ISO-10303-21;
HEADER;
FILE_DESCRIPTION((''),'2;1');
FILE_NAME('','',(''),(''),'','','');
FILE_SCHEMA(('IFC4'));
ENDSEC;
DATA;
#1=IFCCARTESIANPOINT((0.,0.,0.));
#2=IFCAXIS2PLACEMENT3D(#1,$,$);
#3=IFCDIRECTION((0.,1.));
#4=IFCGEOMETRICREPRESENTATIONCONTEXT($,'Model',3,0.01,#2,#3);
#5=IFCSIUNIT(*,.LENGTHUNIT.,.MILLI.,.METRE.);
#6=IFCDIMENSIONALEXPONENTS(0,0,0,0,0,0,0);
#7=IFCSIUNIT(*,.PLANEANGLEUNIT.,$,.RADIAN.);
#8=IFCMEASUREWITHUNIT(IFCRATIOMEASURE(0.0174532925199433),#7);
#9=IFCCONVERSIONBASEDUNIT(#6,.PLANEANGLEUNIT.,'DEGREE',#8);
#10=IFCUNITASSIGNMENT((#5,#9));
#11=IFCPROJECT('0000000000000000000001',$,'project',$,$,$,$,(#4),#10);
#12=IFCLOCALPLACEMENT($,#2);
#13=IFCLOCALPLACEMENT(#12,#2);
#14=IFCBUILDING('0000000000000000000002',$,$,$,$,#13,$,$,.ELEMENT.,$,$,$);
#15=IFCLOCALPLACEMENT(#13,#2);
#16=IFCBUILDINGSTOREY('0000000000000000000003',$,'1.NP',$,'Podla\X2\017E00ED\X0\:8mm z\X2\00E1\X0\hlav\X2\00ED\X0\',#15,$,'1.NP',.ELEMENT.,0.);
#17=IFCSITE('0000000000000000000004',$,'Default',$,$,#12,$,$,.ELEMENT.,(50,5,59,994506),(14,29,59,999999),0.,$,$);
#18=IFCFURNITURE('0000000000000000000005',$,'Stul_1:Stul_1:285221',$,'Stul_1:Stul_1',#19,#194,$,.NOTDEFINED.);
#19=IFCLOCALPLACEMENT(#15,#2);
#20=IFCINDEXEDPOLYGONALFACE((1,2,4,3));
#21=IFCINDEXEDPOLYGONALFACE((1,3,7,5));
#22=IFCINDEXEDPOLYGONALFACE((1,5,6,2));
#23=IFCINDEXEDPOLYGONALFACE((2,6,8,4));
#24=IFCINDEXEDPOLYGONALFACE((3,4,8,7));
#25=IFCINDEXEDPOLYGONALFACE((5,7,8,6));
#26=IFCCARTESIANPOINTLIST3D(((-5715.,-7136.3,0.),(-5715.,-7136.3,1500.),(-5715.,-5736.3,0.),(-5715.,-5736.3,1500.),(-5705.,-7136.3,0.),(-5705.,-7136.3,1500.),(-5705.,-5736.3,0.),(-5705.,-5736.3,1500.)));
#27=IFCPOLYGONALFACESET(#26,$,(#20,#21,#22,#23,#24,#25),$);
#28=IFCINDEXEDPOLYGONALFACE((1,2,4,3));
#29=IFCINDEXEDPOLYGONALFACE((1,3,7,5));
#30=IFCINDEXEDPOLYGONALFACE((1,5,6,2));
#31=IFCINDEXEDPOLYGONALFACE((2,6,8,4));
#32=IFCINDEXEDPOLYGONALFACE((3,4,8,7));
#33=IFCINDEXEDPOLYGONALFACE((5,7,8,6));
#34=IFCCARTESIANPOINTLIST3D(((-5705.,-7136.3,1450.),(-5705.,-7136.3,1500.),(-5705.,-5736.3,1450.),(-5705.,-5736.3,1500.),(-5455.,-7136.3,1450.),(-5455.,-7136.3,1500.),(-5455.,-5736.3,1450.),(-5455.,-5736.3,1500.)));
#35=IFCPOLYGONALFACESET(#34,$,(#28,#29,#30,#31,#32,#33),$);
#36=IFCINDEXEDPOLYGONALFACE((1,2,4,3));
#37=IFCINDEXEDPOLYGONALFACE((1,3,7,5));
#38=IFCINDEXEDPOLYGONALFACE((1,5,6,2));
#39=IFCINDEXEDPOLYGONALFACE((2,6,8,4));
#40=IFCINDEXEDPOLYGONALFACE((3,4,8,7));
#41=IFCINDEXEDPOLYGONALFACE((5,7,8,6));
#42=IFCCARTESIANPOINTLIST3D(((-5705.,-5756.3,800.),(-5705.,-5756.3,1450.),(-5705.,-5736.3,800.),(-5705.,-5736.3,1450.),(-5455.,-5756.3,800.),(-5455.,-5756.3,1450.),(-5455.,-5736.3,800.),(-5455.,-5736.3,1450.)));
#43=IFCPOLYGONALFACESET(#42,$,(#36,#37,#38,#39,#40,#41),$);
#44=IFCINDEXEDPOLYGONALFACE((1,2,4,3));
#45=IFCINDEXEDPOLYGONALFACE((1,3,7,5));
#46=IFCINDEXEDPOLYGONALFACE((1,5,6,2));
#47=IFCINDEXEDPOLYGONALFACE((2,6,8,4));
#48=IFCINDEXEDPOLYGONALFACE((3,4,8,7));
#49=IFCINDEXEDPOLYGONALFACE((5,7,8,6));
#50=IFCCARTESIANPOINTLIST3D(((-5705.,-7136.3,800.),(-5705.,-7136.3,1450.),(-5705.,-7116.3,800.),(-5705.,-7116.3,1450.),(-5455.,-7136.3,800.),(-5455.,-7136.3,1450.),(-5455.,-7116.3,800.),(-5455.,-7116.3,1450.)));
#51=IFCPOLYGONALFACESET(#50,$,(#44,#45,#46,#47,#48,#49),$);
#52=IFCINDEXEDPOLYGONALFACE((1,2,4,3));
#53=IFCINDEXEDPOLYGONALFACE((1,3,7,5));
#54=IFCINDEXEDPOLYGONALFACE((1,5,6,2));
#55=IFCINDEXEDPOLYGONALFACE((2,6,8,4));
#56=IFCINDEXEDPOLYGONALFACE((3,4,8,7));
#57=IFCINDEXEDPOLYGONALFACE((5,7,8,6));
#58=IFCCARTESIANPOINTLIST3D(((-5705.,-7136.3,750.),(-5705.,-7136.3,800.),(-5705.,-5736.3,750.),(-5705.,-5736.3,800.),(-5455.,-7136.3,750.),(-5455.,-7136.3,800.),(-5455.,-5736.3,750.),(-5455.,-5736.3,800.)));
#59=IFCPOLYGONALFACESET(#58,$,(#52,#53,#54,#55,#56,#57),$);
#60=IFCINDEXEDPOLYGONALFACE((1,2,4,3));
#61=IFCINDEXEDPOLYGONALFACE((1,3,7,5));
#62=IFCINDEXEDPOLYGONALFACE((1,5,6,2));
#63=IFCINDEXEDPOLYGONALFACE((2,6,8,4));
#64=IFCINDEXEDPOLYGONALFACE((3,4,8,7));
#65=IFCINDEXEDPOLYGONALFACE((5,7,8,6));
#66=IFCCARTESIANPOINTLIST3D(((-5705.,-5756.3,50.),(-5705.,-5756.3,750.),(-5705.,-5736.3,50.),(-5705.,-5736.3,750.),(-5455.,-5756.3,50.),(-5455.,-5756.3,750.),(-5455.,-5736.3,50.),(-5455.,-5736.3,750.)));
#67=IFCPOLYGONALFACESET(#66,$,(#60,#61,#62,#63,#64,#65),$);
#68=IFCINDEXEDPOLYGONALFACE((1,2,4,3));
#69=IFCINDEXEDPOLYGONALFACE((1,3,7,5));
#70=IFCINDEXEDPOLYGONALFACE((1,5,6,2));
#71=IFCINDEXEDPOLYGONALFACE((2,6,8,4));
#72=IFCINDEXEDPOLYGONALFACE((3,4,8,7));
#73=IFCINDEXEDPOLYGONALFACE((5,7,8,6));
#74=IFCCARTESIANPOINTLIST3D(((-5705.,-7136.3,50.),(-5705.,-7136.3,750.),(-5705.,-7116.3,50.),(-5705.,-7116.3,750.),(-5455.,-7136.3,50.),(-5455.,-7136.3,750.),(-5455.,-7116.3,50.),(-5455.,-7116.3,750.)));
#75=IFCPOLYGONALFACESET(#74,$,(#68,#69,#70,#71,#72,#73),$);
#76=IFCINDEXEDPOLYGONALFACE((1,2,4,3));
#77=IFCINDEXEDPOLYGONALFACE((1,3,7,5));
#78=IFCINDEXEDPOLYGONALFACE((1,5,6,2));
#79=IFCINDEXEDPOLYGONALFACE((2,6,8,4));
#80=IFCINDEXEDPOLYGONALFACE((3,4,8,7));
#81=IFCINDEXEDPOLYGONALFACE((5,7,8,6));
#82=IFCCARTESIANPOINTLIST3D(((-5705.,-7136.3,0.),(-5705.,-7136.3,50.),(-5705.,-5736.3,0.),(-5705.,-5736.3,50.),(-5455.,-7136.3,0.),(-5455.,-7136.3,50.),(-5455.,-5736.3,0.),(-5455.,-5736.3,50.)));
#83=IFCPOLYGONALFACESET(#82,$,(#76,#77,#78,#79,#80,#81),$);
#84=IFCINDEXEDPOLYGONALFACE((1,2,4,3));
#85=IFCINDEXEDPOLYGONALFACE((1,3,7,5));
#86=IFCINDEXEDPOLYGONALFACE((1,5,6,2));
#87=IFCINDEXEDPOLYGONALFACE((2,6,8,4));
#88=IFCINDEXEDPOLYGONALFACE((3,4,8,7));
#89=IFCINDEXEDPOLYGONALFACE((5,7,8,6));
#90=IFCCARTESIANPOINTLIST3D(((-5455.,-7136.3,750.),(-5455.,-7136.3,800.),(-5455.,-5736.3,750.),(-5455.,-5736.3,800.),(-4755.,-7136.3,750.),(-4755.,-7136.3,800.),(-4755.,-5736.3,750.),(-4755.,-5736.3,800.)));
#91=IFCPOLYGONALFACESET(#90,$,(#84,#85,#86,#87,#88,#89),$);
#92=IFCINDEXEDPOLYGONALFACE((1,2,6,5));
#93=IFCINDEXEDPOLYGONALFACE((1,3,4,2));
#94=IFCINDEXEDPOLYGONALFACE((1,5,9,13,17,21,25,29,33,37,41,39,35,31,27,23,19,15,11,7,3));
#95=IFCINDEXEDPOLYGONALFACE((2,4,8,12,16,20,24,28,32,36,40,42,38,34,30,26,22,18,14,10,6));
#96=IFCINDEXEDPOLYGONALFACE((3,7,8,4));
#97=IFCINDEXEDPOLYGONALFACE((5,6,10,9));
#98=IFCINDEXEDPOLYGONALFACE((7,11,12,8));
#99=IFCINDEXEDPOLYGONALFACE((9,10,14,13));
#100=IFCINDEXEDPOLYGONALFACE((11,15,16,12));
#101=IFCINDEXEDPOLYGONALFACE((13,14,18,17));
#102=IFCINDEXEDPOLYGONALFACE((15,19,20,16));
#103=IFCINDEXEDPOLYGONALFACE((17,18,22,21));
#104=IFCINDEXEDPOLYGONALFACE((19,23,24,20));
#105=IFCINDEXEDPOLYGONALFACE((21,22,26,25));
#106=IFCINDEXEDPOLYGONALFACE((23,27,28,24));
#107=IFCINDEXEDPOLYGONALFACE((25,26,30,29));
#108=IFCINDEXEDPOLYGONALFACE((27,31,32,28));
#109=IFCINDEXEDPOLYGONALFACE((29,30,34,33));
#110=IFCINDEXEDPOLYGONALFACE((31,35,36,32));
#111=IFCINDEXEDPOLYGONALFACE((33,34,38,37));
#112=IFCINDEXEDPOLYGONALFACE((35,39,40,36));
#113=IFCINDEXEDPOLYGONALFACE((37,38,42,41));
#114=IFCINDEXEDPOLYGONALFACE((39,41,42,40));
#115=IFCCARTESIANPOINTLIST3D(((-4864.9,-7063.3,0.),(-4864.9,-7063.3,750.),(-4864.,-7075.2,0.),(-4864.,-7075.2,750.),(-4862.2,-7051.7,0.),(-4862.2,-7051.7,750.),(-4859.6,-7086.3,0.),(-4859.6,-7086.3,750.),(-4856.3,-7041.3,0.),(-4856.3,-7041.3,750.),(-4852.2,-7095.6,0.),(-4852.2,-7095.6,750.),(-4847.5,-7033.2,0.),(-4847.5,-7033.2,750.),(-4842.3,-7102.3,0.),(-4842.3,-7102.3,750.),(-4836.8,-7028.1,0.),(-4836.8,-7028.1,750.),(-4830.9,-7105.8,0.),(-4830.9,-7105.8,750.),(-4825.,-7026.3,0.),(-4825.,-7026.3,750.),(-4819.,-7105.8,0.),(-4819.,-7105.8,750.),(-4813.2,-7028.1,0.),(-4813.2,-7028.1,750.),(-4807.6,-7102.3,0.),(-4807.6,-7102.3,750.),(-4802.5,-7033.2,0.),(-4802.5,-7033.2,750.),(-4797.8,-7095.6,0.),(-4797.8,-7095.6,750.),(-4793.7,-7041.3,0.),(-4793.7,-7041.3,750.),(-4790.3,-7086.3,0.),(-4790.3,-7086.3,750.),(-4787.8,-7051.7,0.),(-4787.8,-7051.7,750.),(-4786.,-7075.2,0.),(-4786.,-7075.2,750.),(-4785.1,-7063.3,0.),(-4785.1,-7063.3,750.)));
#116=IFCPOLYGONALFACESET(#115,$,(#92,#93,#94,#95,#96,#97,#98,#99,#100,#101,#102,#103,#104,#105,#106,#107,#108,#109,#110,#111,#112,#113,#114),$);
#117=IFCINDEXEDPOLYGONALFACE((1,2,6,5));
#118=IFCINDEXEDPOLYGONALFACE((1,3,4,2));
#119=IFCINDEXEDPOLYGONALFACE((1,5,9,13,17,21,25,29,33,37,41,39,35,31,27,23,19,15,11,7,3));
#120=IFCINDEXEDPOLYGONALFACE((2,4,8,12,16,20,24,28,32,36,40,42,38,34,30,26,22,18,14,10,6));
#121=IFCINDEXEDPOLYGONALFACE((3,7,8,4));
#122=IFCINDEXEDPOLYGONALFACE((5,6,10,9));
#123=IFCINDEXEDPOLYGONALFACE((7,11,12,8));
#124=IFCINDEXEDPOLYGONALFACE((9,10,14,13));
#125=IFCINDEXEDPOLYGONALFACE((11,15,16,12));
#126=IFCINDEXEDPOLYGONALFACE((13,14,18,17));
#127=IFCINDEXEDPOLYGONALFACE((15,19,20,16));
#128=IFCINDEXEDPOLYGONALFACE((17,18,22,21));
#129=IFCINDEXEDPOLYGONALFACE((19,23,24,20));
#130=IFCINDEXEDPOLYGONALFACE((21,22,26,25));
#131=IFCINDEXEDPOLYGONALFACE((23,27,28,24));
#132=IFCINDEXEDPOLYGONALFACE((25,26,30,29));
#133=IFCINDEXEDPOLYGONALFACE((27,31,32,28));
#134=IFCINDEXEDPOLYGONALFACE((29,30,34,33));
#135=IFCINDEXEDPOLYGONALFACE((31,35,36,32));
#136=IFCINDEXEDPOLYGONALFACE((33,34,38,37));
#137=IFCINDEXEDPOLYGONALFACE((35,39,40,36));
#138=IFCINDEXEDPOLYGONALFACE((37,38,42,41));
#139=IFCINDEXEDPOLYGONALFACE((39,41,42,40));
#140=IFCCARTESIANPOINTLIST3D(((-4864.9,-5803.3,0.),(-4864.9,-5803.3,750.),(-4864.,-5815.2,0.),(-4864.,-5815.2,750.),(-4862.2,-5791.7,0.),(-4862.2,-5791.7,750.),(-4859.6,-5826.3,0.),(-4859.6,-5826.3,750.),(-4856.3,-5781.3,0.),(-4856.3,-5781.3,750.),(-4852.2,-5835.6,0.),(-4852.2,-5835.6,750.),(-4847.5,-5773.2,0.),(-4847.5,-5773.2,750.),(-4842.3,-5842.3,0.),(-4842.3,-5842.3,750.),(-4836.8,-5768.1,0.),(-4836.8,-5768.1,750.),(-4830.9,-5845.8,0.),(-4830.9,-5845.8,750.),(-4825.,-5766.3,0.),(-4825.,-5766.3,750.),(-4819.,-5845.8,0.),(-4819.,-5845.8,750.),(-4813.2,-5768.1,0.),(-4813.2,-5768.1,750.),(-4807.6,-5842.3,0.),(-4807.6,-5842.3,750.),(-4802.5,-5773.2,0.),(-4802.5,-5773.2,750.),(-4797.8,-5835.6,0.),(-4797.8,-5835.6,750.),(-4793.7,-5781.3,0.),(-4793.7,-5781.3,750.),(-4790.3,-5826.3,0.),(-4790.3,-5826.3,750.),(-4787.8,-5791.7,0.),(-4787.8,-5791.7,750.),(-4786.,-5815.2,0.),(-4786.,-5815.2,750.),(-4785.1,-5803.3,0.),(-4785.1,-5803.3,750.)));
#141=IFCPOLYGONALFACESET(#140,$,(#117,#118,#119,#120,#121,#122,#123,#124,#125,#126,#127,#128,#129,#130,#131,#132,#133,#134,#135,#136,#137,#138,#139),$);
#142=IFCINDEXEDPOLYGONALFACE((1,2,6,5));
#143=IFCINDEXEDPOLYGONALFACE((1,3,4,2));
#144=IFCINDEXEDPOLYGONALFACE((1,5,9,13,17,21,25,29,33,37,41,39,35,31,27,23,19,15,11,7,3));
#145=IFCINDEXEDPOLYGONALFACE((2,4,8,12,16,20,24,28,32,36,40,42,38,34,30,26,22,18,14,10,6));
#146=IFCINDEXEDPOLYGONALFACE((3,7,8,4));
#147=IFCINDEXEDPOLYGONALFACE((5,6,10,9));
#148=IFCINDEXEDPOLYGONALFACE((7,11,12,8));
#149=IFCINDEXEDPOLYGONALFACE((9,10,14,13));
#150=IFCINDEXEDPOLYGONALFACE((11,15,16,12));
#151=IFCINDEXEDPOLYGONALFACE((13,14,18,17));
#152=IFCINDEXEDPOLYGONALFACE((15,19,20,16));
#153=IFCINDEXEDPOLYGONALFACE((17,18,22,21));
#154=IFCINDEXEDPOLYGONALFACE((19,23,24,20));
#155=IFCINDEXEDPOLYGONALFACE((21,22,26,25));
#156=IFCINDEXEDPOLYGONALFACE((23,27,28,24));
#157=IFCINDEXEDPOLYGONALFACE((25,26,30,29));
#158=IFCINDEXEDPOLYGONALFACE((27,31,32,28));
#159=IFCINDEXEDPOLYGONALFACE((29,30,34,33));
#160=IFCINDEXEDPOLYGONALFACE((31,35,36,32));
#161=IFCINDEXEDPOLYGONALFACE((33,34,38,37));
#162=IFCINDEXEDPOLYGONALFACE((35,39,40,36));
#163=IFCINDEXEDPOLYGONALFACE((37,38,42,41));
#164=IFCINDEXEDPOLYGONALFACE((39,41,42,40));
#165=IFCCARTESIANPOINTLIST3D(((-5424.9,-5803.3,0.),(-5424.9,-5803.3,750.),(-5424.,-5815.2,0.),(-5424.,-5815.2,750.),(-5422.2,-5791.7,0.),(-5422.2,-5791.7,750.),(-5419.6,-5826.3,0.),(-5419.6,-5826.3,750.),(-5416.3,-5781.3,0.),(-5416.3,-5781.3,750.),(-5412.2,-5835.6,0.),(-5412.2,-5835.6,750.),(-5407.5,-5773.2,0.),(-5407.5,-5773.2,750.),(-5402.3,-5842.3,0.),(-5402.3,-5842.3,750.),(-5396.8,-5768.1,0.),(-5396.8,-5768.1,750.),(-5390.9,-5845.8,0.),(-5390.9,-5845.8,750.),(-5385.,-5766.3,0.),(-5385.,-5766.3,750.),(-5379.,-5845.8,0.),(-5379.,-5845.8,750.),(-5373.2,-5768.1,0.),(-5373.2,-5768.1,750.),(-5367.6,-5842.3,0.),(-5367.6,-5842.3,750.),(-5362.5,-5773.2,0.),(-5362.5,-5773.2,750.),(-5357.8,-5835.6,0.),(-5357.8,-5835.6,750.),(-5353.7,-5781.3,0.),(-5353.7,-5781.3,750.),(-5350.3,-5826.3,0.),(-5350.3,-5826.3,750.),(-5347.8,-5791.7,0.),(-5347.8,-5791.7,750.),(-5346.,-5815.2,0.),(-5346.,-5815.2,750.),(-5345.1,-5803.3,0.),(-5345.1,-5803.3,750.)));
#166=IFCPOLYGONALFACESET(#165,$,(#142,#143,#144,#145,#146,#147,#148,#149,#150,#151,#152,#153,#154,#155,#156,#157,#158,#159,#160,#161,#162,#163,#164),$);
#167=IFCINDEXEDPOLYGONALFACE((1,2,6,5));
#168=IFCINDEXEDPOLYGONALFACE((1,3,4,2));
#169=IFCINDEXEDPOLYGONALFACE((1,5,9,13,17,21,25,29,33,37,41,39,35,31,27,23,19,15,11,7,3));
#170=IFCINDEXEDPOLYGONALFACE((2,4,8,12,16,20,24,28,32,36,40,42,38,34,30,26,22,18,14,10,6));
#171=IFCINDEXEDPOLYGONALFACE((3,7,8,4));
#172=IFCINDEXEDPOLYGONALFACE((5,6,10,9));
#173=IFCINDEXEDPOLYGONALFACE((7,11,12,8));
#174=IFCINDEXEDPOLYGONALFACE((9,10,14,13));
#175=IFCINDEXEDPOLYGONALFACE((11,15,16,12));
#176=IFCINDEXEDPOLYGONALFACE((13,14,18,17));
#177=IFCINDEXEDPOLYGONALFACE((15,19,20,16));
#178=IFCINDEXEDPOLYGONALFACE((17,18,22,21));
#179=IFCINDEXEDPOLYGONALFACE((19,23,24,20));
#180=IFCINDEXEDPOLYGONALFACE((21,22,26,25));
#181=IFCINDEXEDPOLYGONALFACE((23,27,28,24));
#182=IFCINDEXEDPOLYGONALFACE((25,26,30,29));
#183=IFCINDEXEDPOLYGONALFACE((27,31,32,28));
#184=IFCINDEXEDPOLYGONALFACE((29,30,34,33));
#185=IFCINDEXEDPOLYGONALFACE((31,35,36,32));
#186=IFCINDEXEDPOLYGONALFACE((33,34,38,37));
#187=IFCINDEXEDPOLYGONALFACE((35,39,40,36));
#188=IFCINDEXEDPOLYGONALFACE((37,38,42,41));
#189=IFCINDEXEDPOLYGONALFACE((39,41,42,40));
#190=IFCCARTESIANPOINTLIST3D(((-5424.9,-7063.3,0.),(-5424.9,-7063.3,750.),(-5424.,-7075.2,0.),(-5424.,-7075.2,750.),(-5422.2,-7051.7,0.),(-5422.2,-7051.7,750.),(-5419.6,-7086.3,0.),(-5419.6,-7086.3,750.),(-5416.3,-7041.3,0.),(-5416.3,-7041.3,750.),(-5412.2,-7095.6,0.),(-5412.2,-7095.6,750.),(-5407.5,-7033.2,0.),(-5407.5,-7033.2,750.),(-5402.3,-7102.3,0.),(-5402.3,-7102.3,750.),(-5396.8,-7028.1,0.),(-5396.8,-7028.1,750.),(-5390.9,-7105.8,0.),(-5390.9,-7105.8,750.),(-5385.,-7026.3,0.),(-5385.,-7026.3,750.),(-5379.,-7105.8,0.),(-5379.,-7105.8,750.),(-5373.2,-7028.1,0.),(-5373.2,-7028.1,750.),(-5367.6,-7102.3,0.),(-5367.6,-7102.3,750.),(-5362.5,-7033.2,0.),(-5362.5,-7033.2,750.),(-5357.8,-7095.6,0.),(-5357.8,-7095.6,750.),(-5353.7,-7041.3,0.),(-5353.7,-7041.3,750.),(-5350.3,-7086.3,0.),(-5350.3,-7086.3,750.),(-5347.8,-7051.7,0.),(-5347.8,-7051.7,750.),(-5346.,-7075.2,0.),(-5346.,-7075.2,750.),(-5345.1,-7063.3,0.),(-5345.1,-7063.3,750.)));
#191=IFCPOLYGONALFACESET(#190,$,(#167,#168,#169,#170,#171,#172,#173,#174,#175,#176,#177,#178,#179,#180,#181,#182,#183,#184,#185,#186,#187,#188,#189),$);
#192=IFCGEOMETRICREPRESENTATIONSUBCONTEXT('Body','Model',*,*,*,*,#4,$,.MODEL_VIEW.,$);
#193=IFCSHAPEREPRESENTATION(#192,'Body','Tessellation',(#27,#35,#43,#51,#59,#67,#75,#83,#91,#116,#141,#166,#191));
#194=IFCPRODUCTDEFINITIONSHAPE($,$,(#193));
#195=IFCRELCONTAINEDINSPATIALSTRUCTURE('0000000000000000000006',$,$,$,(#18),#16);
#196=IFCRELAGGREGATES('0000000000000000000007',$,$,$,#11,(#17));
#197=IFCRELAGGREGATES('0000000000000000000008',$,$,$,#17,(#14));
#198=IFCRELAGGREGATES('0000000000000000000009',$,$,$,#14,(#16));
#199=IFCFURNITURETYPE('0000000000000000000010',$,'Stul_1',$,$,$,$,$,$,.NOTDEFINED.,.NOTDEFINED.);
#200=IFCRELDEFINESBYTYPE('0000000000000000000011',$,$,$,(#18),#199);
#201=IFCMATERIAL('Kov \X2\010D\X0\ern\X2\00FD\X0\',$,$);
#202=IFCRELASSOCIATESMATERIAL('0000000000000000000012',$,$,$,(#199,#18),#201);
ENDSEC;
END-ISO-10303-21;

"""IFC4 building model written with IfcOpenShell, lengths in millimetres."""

from ifc_helpers import new_model, entity, si_unit, converted_unit, direction, frame, frame_2d, origin, origin_2d_with_axis, place, context, subcontext, project, spatial, rectangle, circle, extrude, source, transform, mapped, material, type_object, type_shapes, element, save


model = new_model("IFC4")

# Units and contexts
model_context = context("Model", 3, precision=0.01, world=origin(), true_north=direction((0.0, 1.0)))
body_context = subcontext(model_context, "Body", "Model", "MODEL_VIEW")
ifc_project = project(units=[si_unit("LENGTHUNIT", "METRE", prefix="MILLI"), converted_unit("PLANEANGLEUNIT", "DEGREE", entity("IfcRatioMeasure", 0.0174532925199433), si_unit("PLANEANGLEUNIT", "RADIAN"), dimensions=[0, 0, 0, 0, 0, 0, 0])], contexts=[model_context])

# Site, building, storey
site_placement = place(None, origin())
site = spatial("IfcSite", under=ifc_project, at=site_placement, Name="Default", CompositionType="ELEMENT", RefLatitude=(50, 5, 59, 994506), RefLongitude=(14, 29, 59, 999999), RefElevation=0.0)
building_placement = place(site_placement, origin())
building = spatial("IfcBuilding", under=site, at=building_placement, CompositionType="ELEMENT")
storey_placement = place(building_placement, origin())
storey = spatial("IfcBuildingStorey", under=building, at=storey_placement, Name="1.NP", ObjectType="Podlaží:8mm záhlaví", LongName="1.NP", CompositionType="ELEMENT", Elevation=0.0)

# Furniture
ifc_material_1 = material(Name="Kov černý")
furniture_type = type_object("IfcFurnitureType", Name="Stul_1", AssemblyPlace="NOTDEFINED", PredefinedType="NOTDEFINED", material=ifc_material_1)
shared_shape_1 = source(origin(), body_context, "Body", "SweptSolid", [
    extrude(rectangle(XDim=1400.0, YDim=10.0, at=origin_2d_with_axis()), frame((0.0, 605.0, 0.0), z_axis=(0.0, 0.0, 1.0), x_axis=(-1.0, 0.0, 0.0)), (0.0, 0.0, 1.0), 1500.0),
    extrude(rectangle(XDim=1400.0, YDim=250.0, at=frame_2d((0.0, 0.0), x_axis=(1.0, 0.0))), frame((0.0, 475.0, 1450.0), z_axis=(0.0, 0.0, 1.0), x_axis=(-1.0, 0.0, 0.0)), (0.0, 0.0, 1.0), 50.0),
    extrude(rectangle(XDim=20.0, YDim=250.0, at=origin_2d_with_axis()), frame((690.0, 475.0, 800.0), z_axis=(0.0, 0.0, 1.0), x_axis=(-1.0, 0.0, 0.0)), (0.0, 0.0, 1.0), 650.0),
    extrude(rectangle(XDim=20.0, YDim=250.0, at=frame_2d((0.0, 0.0), x_axis=(1.0, 0.0))), frame((-690.0, 475.0, 800.0), z_axis=(0.0, 0.0, 1.0), x_axis=(-1.0, 0.0, 0.0)), (0.0, 0.0, 1.0), 650.0),
    extrude(rectangle(XDim=1400.0, YDim=250.0, at=origin_2d_with_axis()), frame((0.0, 475.0, 750.0), z_axis=(0.0, 0.0, 1.0), x_axis=(-1.0, 0.0, 0.0)), (0.0, 0.0, 1.0), 50.0),
    extrude(rectangle(XDim=20.0, YDim=250.0, at=origin_2d_with_axis()), frame((690.0, 475.0, 50.0), z_axis=(0.0, 0.0, 1.0), x_axis=(-1.0, 0.0, 0.0)), (0.0, 0.0, 1.0), 700.0),
    extrude(rectangle(XDim=20.0, YDim=250.0, at=frame_2d((0.0, 0.0), x_axis=(1.0, 0.0))), frame((-690.0, 475.0, 50.0), z_axis=(0.0, 0.0, 1.0), x_axis=(-1.0, 0.0, 0.0)), (0.0, 0.0, 1.0), 700.0),
    extrude(rectangle(XDim=1400.0, YDim=250.0, at=origin_2d_with_axis()), frame((0.0, 475.0, 0.0), z_axis=(0.0, 0.0, 1.0), x_axis=(-1.0, 0.0, 0.0)), (0.0, 0.0, 1.0), 50.0),
    extrude(rectangle(XDim=1400.0, YDim=700.0, at=origin_2d_with_axis()), frame((0.0, 0.0, 750.0), z_axis=(0.0, 0.0, 1.0), x_axis=(-1.0, 0.0, 0.0)), (0.0, 0.0, 1.0), 50.0),
    extrude(circle(Radius=40.0, at=frame_2d((0.0, 0.0), x_axis=(1.0, 0.0))), frame((-630.0, -280.0, 0.0)), (0.0, 0.0, 1.0), 750.0),
    extrude(circle(Radius=40.0, at=frame_2d((0.0, 0.0), x_axis=(1.0, 0.0))), frame((630.0, -280.0, 0.0)), (0.0, 0.0, 1.0), 750.0),
    extrude(circle(Radius=40.0, at=frame_2d((0.0, 0.0), x_axis=(1.0, 0.0))), frame((630.0, 280.0, 0.0)), (0.0, 0.0, 1.0), 750.0),
    extrude(circle(Radius=40.0, at=frame_2d((0.0, 0.0), x_axis=(1.0, 0.0))), frame((-630.0, 280.0, 0.0)), (0.0, 0.0, 1.0), 750.0),
])
type_shapes(furniture_type, [shared_shape_1])
for number, where, z_axis, x_axis, name in (
    (1, (-5105.0, -6436.3, 0.0), (0.0, 0.0, 1.0), (0.0, 1.0, 0.0), "Stul_1:Stul_1:285221"),
):
    element("IfcFurniture", number, at=place(storey_placement, frame(where, z_axis=z_axis, x_axis=x_axis)), inside=storey, type_object=furniture_type, material=ifc_material_1, Name=name, ObjectType="Stul_1:Stul_1", PredefinedType="NOTDEFINED", context=body_context, shape_type="MappedRepresentation", body=[
        mapped(shared_shape_1, transform((0.0, 0.0, 0.0), scale=1.0)),
    ])

save(model, "model.ifc")
